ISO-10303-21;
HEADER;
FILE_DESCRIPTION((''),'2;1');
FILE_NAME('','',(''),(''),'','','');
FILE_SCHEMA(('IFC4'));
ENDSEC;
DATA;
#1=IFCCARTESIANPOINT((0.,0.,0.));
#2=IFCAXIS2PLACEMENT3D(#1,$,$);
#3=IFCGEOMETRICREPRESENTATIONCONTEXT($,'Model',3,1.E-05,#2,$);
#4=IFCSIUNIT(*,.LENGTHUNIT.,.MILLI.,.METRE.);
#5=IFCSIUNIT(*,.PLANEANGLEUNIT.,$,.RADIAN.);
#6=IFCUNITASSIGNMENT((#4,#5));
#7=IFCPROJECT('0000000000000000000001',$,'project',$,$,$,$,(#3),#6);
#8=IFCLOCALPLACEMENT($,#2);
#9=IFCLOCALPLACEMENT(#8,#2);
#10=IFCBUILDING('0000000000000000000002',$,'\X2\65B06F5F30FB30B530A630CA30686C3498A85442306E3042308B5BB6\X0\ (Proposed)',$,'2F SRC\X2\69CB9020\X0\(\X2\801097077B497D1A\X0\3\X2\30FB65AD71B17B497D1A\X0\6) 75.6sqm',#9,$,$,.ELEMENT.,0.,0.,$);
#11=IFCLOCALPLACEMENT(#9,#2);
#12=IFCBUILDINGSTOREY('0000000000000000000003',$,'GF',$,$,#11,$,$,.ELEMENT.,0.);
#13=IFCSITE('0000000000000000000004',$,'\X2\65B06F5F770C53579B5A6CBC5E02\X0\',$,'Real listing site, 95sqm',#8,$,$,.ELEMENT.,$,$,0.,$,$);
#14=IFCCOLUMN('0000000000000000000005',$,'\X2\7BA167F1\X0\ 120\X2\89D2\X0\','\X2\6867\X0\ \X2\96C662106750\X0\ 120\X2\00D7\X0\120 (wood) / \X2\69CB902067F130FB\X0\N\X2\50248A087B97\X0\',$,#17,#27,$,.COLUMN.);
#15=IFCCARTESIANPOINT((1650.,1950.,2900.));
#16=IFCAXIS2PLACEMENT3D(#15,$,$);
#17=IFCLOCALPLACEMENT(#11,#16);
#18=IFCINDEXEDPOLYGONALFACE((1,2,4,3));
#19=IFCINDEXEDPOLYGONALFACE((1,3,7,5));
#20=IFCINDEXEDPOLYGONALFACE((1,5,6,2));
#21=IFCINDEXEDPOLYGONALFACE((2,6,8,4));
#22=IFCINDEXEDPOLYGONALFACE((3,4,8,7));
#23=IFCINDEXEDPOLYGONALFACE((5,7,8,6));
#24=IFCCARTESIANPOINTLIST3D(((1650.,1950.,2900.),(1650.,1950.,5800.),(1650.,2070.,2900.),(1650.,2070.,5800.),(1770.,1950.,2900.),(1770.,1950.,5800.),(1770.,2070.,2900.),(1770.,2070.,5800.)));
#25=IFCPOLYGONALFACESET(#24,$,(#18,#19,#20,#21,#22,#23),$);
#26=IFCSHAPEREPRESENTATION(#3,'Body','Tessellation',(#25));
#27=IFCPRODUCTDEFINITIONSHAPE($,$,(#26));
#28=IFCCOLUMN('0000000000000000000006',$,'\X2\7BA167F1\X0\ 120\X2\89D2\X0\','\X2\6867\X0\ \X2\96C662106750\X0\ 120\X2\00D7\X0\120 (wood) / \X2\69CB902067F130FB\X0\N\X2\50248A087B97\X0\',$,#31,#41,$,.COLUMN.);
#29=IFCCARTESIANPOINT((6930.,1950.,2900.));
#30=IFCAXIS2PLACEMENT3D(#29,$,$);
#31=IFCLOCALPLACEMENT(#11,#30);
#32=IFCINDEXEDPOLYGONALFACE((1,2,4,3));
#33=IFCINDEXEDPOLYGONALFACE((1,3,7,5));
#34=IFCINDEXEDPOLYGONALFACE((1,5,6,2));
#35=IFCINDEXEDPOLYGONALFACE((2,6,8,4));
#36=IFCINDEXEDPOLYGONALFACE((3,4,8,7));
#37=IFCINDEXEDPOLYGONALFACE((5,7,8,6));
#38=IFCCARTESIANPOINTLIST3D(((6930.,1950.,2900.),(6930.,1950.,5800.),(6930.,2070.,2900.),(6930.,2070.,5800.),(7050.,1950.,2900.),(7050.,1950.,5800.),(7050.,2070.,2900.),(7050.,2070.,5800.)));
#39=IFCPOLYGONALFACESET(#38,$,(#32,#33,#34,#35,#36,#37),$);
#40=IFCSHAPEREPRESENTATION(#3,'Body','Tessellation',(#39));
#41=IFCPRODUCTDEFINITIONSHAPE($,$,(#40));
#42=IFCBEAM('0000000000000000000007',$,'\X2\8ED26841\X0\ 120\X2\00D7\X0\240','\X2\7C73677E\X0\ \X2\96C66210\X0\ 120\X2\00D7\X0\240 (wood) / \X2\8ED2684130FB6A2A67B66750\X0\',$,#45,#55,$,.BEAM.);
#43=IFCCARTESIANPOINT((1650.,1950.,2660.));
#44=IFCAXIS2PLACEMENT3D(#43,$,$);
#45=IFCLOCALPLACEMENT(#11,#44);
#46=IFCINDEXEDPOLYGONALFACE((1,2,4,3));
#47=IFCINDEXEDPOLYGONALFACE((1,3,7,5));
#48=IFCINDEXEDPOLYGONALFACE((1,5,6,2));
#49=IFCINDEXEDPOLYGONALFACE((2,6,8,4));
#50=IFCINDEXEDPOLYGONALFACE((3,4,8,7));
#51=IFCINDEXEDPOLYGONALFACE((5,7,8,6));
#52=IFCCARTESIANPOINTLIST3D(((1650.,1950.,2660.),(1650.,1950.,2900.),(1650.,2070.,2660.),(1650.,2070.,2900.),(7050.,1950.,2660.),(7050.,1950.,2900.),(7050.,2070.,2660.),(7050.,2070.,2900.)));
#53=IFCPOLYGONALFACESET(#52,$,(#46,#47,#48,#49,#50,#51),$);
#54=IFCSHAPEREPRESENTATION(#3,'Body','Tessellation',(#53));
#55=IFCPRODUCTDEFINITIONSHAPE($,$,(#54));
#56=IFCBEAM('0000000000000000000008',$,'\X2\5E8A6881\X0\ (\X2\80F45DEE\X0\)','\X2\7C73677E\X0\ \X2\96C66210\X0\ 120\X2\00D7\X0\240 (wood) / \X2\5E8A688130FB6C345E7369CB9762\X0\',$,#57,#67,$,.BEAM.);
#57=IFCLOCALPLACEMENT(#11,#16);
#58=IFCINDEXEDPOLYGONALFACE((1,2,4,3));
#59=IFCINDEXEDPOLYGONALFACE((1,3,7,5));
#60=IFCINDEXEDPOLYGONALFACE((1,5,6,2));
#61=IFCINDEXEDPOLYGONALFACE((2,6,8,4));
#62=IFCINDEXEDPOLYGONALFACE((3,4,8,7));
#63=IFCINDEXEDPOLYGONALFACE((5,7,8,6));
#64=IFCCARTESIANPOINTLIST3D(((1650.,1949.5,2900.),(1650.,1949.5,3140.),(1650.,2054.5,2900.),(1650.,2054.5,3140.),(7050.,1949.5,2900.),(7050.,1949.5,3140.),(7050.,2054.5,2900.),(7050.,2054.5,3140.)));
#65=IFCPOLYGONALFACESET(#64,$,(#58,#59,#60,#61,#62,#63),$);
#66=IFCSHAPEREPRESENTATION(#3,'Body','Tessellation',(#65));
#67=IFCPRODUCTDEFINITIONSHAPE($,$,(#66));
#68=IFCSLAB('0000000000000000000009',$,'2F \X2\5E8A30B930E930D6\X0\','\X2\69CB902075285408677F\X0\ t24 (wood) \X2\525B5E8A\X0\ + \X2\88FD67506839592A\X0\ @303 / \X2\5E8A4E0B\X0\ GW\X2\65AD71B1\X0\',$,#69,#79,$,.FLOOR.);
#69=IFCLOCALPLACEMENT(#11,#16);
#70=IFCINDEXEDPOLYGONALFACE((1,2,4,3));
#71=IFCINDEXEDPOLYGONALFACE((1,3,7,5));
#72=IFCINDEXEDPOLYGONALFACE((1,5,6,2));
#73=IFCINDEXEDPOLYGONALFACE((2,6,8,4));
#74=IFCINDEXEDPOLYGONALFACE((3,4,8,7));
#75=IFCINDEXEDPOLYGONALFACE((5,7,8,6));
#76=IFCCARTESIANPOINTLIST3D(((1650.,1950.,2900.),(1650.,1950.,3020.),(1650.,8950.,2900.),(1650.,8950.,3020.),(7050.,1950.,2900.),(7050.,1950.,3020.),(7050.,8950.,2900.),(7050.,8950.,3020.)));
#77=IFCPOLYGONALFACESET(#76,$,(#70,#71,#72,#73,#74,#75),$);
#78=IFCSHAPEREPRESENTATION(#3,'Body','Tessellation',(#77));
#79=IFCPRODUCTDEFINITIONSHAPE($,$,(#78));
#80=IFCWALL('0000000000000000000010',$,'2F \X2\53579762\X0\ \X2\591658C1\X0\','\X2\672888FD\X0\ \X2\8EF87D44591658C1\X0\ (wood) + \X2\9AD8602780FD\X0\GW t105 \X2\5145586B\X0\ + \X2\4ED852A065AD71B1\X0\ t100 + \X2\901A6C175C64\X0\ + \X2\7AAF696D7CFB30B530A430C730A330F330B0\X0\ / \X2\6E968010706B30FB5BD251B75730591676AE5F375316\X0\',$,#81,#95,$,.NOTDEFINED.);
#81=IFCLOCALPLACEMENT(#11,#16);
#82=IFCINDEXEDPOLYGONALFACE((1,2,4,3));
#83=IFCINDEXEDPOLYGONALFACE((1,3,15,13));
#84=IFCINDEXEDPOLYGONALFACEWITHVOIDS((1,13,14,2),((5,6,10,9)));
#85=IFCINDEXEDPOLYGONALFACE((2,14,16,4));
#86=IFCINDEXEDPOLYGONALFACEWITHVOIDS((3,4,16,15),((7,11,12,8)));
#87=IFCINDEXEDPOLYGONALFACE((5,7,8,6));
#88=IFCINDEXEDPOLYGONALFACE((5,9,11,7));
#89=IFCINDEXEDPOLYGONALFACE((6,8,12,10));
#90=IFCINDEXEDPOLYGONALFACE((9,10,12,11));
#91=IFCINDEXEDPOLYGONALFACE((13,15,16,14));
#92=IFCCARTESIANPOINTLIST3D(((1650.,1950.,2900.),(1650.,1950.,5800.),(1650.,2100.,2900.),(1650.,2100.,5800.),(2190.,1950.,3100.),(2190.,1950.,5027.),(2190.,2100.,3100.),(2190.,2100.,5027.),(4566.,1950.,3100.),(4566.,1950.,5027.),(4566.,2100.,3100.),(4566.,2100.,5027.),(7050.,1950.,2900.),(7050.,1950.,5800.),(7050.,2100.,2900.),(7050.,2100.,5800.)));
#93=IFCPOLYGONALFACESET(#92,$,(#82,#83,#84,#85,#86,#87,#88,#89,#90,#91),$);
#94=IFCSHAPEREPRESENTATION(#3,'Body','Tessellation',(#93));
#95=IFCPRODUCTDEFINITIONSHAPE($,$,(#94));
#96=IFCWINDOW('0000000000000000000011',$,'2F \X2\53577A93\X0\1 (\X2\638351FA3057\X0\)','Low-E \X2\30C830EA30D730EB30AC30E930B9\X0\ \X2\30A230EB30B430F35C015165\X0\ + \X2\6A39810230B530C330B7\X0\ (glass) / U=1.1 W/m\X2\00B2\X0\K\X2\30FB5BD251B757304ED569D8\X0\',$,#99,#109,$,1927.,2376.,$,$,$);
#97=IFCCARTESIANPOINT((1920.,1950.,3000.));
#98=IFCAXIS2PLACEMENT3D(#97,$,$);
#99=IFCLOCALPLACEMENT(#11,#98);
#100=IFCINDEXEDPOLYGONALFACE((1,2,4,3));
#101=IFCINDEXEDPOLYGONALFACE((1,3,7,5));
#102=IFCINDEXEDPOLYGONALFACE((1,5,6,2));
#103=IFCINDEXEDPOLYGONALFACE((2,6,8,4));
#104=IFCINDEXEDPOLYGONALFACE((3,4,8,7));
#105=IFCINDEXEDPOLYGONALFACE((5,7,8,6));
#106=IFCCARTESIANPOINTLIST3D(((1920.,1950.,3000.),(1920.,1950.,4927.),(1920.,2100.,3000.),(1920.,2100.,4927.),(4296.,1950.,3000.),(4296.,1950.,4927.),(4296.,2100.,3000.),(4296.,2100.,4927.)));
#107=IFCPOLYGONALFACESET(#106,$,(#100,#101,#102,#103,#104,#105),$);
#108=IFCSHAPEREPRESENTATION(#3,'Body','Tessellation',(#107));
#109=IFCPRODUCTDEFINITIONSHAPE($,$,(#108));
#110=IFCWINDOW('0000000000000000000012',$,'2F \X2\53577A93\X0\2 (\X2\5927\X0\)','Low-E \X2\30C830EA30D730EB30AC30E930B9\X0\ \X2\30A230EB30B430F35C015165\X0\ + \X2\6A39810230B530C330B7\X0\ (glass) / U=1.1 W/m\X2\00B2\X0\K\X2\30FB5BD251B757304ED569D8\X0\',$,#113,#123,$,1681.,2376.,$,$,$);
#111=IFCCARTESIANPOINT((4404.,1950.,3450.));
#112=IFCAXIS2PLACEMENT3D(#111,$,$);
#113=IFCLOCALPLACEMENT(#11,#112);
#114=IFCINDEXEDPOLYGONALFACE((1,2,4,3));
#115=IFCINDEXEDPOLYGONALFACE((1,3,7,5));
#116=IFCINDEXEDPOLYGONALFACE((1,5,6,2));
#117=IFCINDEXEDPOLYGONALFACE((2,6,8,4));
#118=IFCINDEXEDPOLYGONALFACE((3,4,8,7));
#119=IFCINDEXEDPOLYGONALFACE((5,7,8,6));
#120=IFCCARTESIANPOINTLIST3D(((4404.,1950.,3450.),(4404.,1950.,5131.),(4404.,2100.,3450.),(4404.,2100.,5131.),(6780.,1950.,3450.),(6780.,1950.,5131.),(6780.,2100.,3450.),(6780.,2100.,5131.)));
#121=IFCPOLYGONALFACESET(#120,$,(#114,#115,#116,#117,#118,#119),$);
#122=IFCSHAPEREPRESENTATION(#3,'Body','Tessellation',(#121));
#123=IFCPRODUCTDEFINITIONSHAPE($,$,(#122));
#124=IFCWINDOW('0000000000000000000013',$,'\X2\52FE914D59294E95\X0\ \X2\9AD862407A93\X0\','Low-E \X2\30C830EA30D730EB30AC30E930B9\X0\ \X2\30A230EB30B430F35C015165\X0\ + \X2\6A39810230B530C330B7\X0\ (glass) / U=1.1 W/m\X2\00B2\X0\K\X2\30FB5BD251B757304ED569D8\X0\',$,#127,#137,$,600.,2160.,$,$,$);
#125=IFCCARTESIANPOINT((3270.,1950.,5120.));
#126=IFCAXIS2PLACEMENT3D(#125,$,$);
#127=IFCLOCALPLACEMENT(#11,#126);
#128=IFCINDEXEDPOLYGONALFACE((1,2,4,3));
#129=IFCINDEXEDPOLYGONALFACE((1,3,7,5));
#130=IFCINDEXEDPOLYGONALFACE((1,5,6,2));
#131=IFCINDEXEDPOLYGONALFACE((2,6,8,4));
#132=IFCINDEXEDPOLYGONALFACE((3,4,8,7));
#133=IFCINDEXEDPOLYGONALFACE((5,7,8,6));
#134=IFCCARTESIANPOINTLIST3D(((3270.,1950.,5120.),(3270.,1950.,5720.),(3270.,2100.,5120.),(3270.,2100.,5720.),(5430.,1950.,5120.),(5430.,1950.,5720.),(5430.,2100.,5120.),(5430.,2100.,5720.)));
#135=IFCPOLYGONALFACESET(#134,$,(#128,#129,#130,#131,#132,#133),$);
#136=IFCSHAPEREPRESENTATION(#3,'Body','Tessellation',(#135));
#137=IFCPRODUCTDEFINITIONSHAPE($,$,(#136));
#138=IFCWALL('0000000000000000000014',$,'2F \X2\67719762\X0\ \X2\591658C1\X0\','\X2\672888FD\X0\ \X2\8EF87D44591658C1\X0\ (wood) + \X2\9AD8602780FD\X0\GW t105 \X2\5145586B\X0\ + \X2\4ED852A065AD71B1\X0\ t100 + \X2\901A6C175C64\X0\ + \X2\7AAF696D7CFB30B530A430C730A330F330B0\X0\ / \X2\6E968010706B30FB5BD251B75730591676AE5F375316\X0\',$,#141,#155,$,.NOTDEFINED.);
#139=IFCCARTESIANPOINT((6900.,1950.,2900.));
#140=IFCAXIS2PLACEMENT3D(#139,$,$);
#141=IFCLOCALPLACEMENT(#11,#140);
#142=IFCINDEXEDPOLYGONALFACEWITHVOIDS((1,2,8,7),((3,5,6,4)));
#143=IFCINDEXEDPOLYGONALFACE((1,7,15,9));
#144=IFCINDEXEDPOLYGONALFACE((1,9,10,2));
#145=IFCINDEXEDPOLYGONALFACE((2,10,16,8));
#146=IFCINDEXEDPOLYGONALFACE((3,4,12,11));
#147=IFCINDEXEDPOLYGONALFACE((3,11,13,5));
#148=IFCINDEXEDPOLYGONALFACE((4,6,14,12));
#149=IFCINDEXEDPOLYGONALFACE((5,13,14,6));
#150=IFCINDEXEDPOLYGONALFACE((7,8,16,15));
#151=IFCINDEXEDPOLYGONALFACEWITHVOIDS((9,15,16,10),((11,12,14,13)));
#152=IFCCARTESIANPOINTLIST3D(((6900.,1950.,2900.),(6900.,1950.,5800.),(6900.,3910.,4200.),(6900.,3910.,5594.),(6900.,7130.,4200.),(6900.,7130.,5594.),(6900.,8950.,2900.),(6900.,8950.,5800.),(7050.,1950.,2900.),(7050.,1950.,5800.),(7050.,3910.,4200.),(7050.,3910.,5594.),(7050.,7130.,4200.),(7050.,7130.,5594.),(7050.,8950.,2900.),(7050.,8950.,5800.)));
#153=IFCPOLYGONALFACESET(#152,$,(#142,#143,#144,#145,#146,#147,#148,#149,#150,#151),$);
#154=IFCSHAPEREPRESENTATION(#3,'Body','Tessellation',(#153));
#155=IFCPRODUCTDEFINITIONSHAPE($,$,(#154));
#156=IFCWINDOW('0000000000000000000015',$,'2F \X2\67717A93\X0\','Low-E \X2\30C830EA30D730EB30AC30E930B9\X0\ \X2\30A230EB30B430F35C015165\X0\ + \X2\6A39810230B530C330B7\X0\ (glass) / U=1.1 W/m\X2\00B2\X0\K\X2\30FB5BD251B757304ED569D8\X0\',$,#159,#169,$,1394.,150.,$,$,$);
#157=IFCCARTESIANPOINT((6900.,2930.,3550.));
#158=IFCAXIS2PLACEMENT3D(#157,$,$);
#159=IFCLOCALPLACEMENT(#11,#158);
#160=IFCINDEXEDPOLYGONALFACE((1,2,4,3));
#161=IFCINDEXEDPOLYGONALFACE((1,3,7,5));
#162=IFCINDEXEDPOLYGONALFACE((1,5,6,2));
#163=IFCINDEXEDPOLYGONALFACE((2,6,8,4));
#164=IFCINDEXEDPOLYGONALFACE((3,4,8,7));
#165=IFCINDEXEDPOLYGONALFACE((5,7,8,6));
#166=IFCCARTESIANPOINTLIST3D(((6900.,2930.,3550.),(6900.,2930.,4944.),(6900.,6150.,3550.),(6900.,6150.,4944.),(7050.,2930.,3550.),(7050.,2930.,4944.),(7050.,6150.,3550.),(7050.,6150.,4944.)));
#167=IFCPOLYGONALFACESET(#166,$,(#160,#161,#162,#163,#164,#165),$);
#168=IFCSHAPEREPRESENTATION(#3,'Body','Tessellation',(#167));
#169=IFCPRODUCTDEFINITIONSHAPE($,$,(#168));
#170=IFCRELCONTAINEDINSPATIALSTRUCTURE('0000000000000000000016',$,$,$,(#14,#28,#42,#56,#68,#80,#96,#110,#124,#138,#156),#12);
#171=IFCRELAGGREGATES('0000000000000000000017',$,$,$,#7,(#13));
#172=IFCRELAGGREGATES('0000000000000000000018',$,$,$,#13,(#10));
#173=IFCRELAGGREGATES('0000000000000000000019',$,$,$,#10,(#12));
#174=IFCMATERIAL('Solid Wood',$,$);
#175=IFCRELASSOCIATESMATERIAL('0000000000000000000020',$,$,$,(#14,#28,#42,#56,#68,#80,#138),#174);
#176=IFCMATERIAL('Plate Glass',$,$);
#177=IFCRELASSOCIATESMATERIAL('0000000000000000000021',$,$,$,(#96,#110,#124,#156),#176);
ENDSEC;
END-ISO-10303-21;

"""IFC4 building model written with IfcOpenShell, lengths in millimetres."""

from ifc_helpers import new_model, si_unit, frame, frame_2d, origin, place, context, project, spatial, rectangle, extrude, material, element, fill, save


model = new_model("IFC4")

# Units and contexts
model_context = context("Model", 3, precision=1e-05, world=origin())
ifc_project = project(units=[si_unit("LENGTHUNIT", "METRE", prefix="MILLI"), si_unit("PLANEANGLEUNIT", "RADIAN")], contexts=[model_context])

# Site, building, storey
site_placement = place(None, origin())
site = spatial("IfcSite", under=ifc_project, at=site_placement, Name="新潟県南魚沼市", ObjectType="Real listing site, 95sqm", CompositionType="ELEMENT", RefElevation=0.0)
building_placement = place(site_placement, origin())
building = spatial("IfcBuilding", under=site, at=building_placement, Name="新潟・サウナと水風呂のある家 (Proposed)", ObjectType="2F SRC構造(耐震等級3・断熱等級6) 75.6sqm", CompositionType="ELEMENT", ElevationOfRefHeight=0.0, ElevationOfTerrain=0.0)
storey_placement = place(building_placement, origin())
storey = spatial("IfcBuildingStorey", under=building, at=storey_placement, Name="GF", CompositionType="ELEMENT", Elevation=0.0)

# Columns
ifc_material_1 = material(Name="Solid Wood")
column_1_placement = place(storey_placement, frame((1650.0, 1950.0, 2900.0)))
element("IfcColumn", 1, at=column_1_placement, inside=storey, material=ifc_material_1, Name="管柱 120角", Description="桧 集成材 120×120 (wood) / 構造柱・N値計算", PredefinedType="COLUMN", context=model_context, shape_type="SweptSolid", body=[
    extrude(rectangle(XDim=120.0, YDim=120.0, at=frame_2d((60.0, 60.0))), frame((1650.0, 1950.0, 2900.0)), (0.0, 0.0, 1.0), 2900.0),
])
column_2_placement = place(storey_placement, frame((6930.0, 1950.0, 2900.0)))
element("IfcColumn", 2, at=column_2_placement, inside=storey, material=ifc_material_1, Name="管柱 120角", Description="桧 集成材 120×120 (wood) / 構造柱・N値計算", PredefinedType="COLUMN", context=model_context, shape_type="SweptSolid", body=[
    extrude(rectangle(XDim=120.0, YDim=120.0, at=frame_2d((60.0, 60.0))), frame((6930.0, 1950.0, 2900.0)), (0.0, 0.0, 1.0), 2900.0),
])

# Beams
beam_1_placement = place(storey_placement, frame((1650.0, 1950.0, 2660.0)))
element("IfcBeam", 3, at=beam_1_placement, inside=storey, material=ifc_material_1, Name="軒桁 120×240", Description="米松 集成 120×240 (wood) / 軒桁・横架材", PredefinedType="BEAM", context=model_context, shape_type="SweptSolid", body=[
    extrude(rectangle(XDim=5400.0, YDim=120.0, at=frame_2d((2700.0, 60.0))), frame((1650.0, 1950.0, 2660.0)), (0.0, 0.0, 1.0), 240.0),
])
beam_2_placement = place(storey_placement, frame((1650.0, 1950.0, 2900.0)))
element("IfcBeam", 4, at=beam_2_placement, inside=storey, material=ifc_material_1, Name="床梁 (胴差)", Description="米松 集成 120×240 (wood) / 床梁・水平構面", PredefinedType="BEAM", context=model_context, shape_type="SweptSolid", body=[
    extrude(rectangle(XDim=5400.0, YDim=105.0, at=frame_2d((2700.0, 52.0))), frame((1650.0, 1950.0, 2900.0)), (0.0, 0.0, 1.0), 240.0),
])

# Slab
slab_placement = place(storey_placement, frame((1650.0, 1950.0, 2900.0)))
element("IfcSlab", 5, at=slab_placement, inside=storey, material=ifc_material_1, Name="2F 床スラブ", Description="構造用合板 t24 (wood) 剛床 + 製材根太 @303 / 床下 GW断熱", PredefinedType="FLOOR", context=model_context, shape_type="SweptSolid", body=[
    extrude(rectangle(XDim=5400.0, YDim=7000.0, at=frame_2d((2700.0, 3500.0))), frame((1650.0, 1950.0, 2900.0)), (0.0, 0.0, 1.0), 120.0),
])

# Wall, openings, windows
wall_1_placement = place(storey_placement, frame((1650.0, 1950.0, 2900.0)))
wall_1 = element("IfcWall", 6, at=wall_1_placement, inside=storey, material=ifc_material_1, Name="2F 南面 外壁", Description="木製 軸組外壁 (wood) + 高性能GW t105 充填 + 付加断熱 t100 + 通気層 + 窯業系サイディング / 準耐火・寒冷地外皮強化", PredefinedType="NOTDEFINED", context=model_context, shape_type="SweptSolid", body=[
    extrude(rectangle(XDim=5400.0, YDim=150.0, at=frame_2d((2700.0, 75.0))), frame((1650.0, 1950.0, 2900.0)), (0.0, 0.0, 1.0), 2900.0),
])
opening_1_placement = place(storey_placement, frame((1920.0, 1950.0, 3000.0)))
opening_1 = element("IfcOpeningElement", 7, at=opening_1_placement, cuts=wall_1, PredefinedType="NOTDEFINED", context=model_context, shape_type="SweptSolid", body=[
    extrude(rectangle(XDim=2376.0, YDim=150.0, at=frame_2d((1188.0, 75.0))), frame((1920.0, 1950.0, 3000.0)), (0.0, 0.0, 1.0), 1927.0),
])
opening_2_placement = place(storey_placement, frame((4404.0, 1950.0, 3450.0)))
opening_2 = element("IfcOpeningElement", 8, at=opening_2_placement, cuts=wall_1, PredefinedType="NOTDEFINED", context=model_context, shape_type="SweptSolid", body=[
    extrude(rectangle(XDim=2376.0, YDim=150.0, at=frame_2d((1188.0, 75.0))), frame((4404.0, 1950.0, 3450.0)), (0.0, 0.0, 1.0), 1681.0),
])
opening_3_placement = place(storey_placement, frame((3270.0, 1950.0, 5120.0)))
opening_3 = element("IfcOpeningElement", 9, at=opening_3_placement, cuts=wall_1, PredefinedType="NOTDEFINED", context=model_context, shape_type="SweptSolid", body=[
    extrude(rectangle(XDim=2160.0, YDim=150.0, at=frame_2d((1080.0, 75.0))), frame((3270.0, 1950.0, 5120.0)), (0.0, 0.0, 1.0), 600.0),
])
ifc_material_2 = material(Name="Plate Glass")
window_1_placement = place(storey_placement, frame((1920.0, 1950.0, 3000.0)))
window_1 = element("IfcWindow", 10, at=window_1_placement, inside=storey, material=ifc_material_2, Name="2F 南窓1 (掃出し)", Description="Low-E トリプルガラス アルゴン封入 + 樹脂サッシ (glass) / U=1.1 W/m²K・寒冷地仕様", OverallHeight=1927.0, OverallWidth=2376.0, context=model_context, shape_type="SweptSolid", body=[
    extrude(rectangle(XDim=2376.0, YDim=150.0, at=frame_2d((1188.0, 75.0))), frame((1920.0, 1950.0, 3000.0)), (0.0, 0.0, 1.0), 1927.0),
])
fill(opening_1, window_1)
window_2_placement = place(storey_placement, frame((4404.0, 1950.0, 3450.0)))
window_2 = element("IfcWindow", 11, at=window_2_placement, inside=storey, material=ifc_material_2, Name="2F 南窓2 (大)", Description="Low-E トリプルガラス アルゴン封入 + 樹脂サッシ (glass) / U=1.1 W/m²K・寒冷地仕様", OverallHeight=1681.0, OverallWidth=2376.0, context=model_context, shape_type="SweptSolid", body=[
    extrude(rectangle(XDim=2376.0, YDim=150.0, at=frame_2d((1188.0, 75.0))), frame((4404.0, 1950.0, 3450.0)), (0.0, 0.0, 1.0), 1681.0),
])
fill(opening_2, window_2)
window_3_placement = place(storey_placement, frame((3270.0, 1950.0, 5120.0)))
window_3 = element("IfcWindow", 12, at=window_3_placement, inside=storey, material=ifc_material_2, Name="勾配天井 高所窓", Description="Low-E トリプルガラス アルゴン封入 + 樹脂サッシ (glass) / U=1.1 W/m²K・寒冷地仕様", OverallHeight=600.0, OverallWidth=2160.0, context=model_context, shape_type="SweptSolid", body=[
    extrude(rectangle(XDim=2160.0, YDim=150.0, at=frame_2d((1080.0, 75.0))), frame((3270.0, 1950.0, 5120.0)), (0.0, 0.0, 1.0), 600.0),
])
fill(opening_3, window_3)

# Wall, opening, window
wall_2_placement = place(storey_placement, frame((6900.0, 1950.0, 2900.0)))
wall_2 = element("IfcWall", 13, at=wall_2_placement, inside=storey, material=ifc_material_1, Name="2F 東面 外壁", Description="木製 軸組外壁 (wood) + 高性能GW t105 充填 + 付加断熱 t100 + 通気層 + 窯業系サイディング / 準耐火・寒冷地外皮強化", PredefinedType="NOTDEFINED", context=model_context, shape_type="SweptSolid", body=[
    extrude(rectangle(XDim=150.0, YDim=7000.0, at=frame_2d((75.0, 3500.0))), frame((6900.0, 1950.0, 2900.0)), (0.0, 0.0, 1.0), 2900.0),
])
opening_4_placement = place(storey_placement, frame((6900.0, 2930.0, 3550.0)))
opening_4 = element("IfcOpeningElement", 14, at=opening_4_placement, cuts=wall_2, PredefinedType="NOTDEFINED", context=model_context, shape_type="SweptSolid", body=[
    extrude(rectangle(XDim=150.0, YDim=3220.0, at=frame_2d((75.0, 1610.0))), frame((6900.0, 2930.0, 3550.0)), (0.0, 0.0, 1.0), 1394.0),
])
window_4_placement = place(storey_placement, frame((6900.0, 2930.0, 3550.0)))
window_4 = element("IfcWindow", 15, at=window_4_placement, inside=storey, material=ifc_material_2, Name="2F 東窓", Description="Low-E トリプルガラス アルゴン封入 + 樹脂サッシ (glass) / U=1.1 W/m²K・寒冷地仕様", OverallHeight=1394.0, OverallWidth=150.0, context=model_context, shape_type="SweptSolid", body=[
    extrude(rectangle(XDim=150.0, YDim=3220.0, at=frame_2d((75.0, 1610.0))), frame((6900.0, 2930.0, 3550.0)), (0.0, 0.0, 1.0), 1394.0),
])
fill(opening_4, window_4)

save(model, "model.ifc")
